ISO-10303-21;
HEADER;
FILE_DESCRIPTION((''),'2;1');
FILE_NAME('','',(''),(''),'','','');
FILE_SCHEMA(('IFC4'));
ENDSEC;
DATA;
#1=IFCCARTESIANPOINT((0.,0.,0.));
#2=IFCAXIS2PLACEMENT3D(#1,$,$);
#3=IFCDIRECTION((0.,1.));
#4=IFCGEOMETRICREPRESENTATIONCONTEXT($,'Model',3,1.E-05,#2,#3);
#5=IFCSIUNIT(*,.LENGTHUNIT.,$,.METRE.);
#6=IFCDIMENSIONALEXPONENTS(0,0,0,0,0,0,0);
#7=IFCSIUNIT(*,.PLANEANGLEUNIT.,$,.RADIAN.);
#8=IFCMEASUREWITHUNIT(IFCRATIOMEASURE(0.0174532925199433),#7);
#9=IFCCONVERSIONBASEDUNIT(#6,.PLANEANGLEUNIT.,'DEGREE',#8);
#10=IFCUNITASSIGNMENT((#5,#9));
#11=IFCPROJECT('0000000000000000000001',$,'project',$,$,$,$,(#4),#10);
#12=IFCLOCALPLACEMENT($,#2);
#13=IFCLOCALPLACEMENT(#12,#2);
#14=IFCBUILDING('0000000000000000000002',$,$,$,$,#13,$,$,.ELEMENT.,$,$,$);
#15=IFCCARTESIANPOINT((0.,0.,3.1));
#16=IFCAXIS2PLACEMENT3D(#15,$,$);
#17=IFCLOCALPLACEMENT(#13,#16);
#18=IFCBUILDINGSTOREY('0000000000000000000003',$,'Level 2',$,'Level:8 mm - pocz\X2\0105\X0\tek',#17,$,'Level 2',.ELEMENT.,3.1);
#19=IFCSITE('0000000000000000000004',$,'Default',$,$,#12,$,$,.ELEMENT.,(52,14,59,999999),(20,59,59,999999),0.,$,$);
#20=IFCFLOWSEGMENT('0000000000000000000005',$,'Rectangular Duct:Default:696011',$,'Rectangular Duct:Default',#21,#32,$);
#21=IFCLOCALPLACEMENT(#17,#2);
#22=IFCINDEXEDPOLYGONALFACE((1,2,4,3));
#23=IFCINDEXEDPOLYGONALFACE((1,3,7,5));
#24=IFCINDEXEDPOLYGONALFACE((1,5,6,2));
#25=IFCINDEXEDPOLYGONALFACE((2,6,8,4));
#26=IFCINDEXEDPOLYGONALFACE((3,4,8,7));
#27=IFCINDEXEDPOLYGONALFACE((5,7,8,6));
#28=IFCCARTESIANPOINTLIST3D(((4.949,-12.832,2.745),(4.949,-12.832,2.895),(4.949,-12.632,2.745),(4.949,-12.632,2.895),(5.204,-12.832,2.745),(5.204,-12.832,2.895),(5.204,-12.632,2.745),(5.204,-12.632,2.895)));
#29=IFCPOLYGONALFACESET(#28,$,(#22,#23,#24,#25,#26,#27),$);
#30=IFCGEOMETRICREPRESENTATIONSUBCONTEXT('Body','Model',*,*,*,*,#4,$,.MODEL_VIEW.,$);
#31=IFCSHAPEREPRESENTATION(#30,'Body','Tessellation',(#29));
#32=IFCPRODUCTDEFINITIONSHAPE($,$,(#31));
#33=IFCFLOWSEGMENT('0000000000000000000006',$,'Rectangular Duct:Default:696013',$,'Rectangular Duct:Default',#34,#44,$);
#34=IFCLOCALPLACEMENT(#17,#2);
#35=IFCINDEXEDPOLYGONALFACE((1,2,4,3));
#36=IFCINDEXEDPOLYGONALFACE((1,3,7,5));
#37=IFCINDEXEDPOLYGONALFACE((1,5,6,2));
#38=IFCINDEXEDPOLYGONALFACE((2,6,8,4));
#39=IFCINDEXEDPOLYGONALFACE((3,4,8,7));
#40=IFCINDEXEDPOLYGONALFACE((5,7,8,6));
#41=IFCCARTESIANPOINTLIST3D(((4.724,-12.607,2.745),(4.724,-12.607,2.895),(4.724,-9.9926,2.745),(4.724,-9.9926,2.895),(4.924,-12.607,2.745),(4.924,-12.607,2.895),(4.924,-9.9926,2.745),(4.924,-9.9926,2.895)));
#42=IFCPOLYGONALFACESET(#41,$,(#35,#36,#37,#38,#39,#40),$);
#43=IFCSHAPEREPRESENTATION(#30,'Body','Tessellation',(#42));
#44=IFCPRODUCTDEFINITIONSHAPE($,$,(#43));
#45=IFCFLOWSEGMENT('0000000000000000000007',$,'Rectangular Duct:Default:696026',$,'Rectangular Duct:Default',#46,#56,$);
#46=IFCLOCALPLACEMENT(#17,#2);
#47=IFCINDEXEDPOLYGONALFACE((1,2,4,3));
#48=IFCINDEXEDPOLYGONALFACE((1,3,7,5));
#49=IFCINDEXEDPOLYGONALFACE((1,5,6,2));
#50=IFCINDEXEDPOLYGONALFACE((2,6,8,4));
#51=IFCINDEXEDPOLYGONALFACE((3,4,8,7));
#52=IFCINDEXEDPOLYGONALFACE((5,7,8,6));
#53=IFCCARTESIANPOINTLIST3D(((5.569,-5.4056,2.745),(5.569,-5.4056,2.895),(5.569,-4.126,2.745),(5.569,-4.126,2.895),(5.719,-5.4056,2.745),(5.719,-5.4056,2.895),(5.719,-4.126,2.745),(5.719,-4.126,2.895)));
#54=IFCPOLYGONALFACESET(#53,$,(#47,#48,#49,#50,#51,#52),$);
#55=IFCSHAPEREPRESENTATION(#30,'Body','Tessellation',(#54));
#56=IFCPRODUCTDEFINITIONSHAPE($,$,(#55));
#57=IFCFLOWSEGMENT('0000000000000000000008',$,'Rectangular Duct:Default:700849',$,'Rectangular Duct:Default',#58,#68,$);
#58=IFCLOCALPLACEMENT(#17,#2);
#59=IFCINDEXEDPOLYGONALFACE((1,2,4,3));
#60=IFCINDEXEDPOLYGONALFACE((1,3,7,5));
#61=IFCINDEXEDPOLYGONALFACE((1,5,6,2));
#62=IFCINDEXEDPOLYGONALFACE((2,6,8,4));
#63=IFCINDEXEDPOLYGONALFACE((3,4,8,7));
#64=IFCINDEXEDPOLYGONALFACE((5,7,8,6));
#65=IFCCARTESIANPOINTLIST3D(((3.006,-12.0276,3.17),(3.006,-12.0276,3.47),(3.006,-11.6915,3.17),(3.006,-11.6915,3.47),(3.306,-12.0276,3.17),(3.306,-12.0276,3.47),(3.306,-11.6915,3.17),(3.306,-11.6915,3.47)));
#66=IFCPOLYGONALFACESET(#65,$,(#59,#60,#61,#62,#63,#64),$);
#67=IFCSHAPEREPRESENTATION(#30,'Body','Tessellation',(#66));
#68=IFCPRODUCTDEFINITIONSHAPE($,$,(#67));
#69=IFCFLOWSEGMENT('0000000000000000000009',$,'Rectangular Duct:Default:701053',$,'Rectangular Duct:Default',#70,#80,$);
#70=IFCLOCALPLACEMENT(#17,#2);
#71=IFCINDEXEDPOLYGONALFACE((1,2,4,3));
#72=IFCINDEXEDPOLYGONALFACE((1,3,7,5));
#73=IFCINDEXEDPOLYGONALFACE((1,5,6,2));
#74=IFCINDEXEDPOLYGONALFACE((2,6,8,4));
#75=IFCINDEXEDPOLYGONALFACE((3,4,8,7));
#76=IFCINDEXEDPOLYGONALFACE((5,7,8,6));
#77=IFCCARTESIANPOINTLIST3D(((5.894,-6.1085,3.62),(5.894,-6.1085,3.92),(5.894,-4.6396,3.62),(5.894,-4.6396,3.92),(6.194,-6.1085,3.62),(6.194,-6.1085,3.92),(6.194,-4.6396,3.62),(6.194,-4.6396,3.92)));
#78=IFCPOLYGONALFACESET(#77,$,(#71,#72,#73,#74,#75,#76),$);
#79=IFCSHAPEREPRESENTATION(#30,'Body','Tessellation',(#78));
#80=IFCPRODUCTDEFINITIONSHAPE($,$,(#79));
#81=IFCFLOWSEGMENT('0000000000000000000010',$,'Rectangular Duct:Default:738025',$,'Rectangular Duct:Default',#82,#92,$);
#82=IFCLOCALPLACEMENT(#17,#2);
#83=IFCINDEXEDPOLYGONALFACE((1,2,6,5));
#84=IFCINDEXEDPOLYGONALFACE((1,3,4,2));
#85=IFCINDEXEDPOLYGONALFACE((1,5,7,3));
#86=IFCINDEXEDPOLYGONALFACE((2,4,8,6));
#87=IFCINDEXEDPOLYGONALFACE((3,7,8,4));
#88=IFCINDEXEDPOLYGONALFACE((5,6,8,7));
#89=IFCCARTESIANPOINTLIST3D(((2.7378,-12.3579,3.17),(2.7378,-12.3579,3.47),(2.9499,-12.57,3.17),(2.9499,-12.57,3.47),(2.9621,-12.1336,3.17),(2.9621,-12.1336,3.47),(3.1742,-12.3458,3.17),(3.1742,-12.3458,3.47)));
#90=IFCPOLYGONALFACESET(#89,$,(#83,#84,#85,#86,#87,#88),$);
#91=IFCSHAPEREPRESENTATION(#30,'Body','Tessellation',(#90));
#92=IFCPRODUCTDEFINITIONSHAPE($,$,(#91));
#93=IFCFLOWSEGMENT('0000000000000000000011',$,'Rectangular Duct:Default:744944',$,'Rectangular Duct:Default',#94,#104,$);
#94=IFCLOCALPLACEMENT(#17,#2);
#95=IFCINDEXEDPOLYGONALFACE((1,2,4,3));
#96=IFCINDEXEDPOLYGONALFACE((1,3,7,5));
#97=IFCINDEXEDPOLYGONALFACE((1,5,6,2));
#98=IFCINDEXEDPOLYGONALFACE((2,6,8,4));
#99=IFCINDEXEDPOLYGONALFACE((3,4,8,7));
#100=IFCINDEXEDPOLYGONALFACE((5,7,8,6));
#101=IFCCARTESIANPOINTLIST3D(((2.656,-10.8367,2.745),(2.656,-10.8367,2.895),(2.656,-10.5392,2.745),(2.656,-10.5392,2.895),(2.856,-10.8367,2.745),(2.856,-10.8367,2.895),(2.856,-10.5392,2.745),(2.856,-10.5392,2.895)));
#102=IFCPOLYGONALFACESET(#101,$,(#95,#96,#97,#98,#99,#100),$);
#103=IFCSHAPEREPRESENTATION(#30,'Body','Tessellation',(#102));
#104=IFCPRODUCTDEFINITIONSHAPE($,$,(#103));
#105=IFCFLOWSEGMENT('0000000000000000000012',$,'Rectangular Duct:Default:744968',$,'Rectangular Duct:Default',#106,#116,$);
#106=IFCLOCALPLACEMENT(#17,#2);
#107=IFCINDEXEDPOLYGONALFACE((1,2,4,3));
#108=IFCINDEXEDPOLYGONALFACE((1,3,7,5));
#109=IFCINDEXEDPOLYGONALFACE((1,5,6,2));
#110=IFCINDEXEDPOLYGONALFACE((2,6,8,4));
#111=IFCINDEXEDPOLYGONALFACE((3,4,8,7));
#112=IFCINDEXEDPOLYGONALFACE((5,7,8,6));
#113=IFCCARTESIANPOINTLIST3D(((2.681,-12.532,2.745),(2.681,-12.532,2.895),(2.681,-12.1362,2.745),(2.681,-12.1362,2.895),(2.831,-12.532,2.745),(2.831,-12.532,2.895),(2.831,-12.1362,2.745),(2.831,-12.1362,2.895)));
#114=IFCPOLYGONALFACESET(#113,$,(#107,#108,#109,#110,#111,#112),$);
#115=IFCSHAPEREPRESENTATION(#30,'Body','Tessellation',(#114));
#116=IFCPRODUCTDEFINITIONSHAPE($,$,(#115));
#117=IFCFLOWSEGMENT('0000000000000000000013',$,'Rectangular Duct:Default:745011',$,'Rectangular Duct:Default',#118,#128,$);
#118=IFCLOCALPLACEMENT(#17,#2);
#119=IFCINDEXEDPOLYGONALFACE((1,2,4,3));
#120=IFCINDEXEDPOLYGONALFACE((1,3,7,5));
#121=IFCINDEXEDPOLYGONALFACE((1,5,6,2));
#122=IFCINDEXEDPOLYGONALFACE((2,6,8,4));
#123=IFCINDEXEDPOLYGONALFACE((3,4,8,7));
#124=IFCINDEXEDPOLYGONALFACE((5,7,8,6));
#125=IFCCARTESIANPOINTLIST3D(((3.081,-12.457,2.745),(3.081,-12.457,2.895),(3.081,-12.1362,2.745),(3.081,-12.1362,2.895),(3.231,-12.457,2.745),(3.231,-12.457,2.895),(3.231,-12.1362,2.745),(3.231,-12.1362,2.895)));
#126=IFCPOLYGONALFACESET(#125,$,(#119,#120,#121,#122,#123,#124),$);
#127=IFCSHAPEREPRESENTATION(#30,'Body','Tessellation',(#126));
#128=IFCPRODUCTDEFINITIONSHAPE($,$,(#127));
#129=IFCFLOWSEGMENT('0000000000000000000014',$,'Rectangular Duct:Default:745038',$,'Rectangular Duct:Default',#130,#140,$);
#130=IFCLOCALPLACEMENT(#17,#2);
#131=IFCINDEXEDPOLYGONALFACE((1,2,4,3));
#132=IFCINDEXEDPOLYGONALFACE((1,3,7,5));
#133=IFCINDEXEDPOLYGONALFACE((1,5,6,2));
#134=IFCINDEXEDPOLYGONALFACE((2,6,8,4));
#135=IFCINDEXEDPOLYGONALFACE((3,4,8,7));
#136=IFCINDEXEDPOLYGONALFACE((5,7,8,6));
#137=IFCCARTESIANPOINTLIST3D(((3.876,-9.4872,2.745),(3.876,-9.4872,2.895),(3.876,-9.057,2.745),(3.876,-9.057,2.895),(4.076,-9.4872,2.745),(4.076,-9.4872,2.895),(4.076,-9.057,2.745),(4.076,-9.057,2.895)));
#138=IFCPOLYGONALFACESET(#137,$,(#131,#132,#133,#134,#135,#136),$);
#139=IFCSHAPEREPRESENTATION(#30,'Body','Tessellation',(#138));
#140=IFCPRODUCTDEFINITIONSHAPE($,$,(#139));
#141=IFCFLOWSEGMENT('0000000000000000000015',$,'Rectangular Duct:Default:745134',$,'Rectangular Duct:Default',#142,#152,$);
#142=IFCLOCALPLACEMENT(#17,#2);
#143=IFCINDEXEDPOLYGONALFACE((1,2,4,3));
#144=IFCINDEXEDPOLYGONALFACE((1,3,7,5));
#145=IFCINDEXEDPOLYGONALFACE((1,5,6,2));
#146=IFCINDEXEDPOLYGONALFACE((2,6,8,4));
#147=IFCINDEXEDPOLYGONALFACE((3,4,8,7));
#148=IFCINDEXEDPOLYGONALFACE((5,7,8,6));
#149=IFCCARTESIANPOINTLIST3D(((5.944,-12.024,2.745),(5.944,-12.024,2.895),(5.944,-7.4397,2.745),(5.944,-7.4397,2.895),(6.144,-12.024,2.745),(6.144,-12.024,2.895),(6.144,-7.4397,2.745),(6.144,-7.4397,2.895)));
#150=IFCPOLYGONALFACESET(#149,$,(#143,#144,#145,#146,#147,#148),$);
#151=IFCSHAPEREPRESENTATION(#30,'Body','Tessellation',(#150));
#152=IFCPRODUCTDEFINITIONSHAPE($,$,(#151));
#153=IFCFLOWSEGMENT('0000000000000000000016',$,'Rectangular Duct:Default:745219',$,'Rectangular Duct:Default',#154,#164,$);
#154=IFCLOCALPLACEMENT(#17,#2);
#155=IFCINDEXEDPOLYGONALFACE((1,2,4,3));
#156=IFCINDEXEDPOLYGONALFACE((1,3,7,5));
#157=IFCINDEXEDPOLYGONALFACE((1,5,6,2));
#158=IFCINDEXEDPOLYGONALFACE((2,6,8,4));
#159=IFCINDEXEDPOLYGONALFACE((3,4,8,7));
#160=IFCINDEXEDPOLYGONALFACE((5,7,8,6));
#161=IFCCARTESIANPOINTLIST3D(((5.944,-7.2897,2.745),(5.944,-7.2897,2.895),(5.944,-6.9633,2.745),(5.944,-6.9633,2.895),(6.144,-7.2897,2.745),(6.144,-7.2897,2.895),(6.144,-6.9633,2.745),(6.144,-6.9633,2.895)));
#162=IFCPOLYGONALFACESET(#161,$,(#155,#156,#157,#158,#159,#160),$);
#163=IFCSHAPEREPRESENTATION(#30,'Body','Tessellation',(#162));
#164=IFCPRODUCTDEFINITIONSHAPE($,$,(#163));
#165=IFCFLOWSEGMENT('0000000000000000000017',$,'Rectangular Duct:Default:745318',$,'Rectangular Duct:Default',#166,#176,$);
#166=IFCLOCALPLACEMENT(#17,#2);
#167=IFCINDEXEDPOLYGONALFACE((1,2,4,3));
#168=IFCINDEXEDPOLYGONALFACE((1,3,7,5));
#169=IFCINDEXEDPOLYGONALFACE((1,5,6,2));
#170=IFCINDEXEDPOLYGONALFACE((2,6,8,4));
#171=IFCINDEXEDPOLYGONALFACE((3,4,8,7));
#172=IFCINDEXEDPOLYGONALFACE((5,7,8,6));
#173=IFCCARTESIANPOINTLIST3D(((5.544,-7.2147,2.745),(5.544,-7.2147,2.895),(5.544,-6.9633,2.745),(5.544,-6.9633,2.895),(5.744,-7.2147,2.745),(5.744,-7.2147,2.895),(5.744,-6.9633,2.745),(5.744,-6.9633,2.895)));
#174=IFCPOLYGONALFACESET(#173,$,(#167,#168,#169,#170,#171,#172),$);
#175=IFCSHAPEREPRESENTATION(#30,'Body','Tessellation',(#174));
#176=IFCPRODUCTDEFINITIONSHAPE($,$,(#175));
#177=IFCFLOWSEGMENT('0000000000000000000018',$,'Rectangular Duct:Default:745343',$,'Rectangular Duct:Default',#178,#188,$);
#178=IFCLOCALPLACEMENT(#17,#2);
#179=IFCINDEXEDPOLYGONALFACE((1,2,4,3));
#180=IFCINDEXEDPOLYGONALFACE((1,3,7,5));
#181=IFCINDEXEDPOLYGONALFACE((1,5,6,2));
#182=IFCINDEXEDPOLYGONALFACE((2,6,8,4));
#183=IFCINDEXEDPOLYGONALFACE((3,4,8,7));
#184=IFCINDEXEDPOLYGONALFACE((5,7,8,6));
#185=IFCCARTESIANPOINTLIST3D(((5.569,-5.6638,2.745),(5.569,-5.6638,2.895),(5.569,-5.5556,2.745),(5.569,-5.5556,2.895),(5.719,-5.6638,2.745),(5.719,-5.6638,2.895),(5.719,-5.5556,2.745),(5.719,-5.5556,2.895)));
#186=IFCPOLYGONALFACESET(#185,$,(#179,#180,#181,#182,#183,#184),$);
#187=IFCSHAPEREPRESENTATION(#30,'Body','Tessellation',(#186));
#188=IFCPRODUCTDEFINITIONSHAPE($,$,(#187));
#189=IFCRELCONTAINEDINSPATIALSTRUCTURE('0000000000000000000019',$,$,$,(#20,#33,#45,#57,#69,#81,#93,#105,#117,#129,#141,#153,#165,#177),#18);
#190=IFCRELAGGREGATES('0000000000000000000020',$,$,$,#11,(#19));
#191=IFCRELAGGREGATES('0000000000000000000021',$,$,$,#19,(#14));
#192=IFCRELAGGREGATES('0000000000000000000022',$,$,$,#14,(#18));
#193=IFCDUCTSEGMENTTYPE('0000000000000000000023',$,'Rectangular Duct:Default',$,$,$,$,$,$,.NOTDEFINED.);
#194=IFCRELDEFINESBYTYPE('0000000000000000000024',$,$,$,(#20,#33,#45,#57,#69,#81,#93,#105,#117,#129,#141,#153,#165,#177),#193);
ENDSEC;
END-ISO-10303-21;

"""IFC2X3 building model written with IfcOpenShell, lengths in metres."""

from ifc_helpers import new_model, entity, si_unit, converted_unit, direction, frame, frame_2d, origin, origin_2d_with_axis, place, context, subcontext, project, spatial, rectangle, extrude, type_object, element, save


model = new_model("IFC2X3")

# Units and contexts
model_context = context("Model", 3, precision=1e-05, world=origin(), true_north=direction((0.0, 1.0)))
body_context = subcontext(model_context, "Body", "Model", "MODEL_VIEW")
ifc_project = project(units=[si_unit("LENGTHUNIT", "METRE"), converted_unit("PLANEANGLEUNIT", "DEGREE", entity("IfcRatioMeasure", 0.0174532925199433), si_unit("PLANEANGLEUNIT", "RADIAN"), dimensions=[0, 0, 0, 0, 0, 0, 0])], contexts=[model_context])

# Site, building, storey
site_placement = place(None, origin())
site = spatial("IfcSite", under=ifc_project, at=site_placement, Name="Default", CompositionType="ELEMENT", RefLatitude=(52, 14, 59, 999999), RefLongitude=(20, 59, 59, 999999), RefElevation=0.0)
building_placement = place(site_placement, origin())
building = spatial("IfcBuilding", under=site, at=building_placement, CompositionType="ELEMENT")
storey_placement = place(building_placement, frame((0.0, 0.0, 3.1)))
storey = spatial("IfcBuildingStorey", under=building, at=storey_placement, Name="Level 2", ObjectType="Level:8 mm - początek", LongName="Level 2", CompositionType="ELEMENT", Elevation=3.1)

# Flow segments
duct_segment_type = type_object("IfcDuctSegmentType", Name="Rectangular Duct:Default", PredefinedType="NOTDEFINED")
flow_segment_1_placement = place(storey_placement, origin())
element("IfcFlowSegment", 1, at=flow_segment_1_placement, inside=storey, type_object=duct_segment_type, Name="Rectangular Duct:Default:696011", ObjectType="Rectangular Duct:Default", context=body_context, shape_type="SweptSolid", body=[
    extrude(rectangle(XDim=0.255, YDim=0.2, at=frame_2d((0.0, 0.0), x_axis=(1.0, 0.0))), frame((5.0765, -12.732, 2.745)), (0.0, 0.0, 1.0), 0.15),
])
flow_segment_2_placement = place(storey_placement, origin())
element("IfcFlowSegment", 2, at=flow_segment_2_placement, inside=storey, type_object=duct_segment_type, Name="Rectangular Duct:Default:696013", ObjectType="Rectangular Duct:Default", context=body_context, shape_type="SweptSolid", body=[
    extrude(rectangle(XDim=2.6144, YDim=0.2, at=frame_2d((0.0, 0.0), x_axis=(1.0, 0.0))), frame((4.824, -11.2998, 2.745), z_axis=(0.0, 0.0, 1.0), x_axis=(0.0, -1.0, 0.0)), (0.0, 0.0, 1.0), 0.15),
])
flow_segment_3_placement = place(storey_placement, origin())
element("IfcFlowSegment", 3, at=flow_segment_3_placement, inside=storey, type_object=duct_segment_type, Name="Rectangular Duct:Default:696026", ObjectType="Rectangular Duct:Default", context=body_context, shape_type="SweptSolid", body=[
    extrude(rectangle(XDim=1.2796, YDim=0.15, at=frame_2d((0.0, 0.0), x_axis=(1.0, 0.0))), frame((5.644, -4.7658, 2.745), z_axis=(0.0, 0.0, 1.0), x_axis=(0.0, 1.0, 0.0)), (0.0, 0.0, 1.0), 0.15),
])
flow_segment_4_placement = place(storey_placement, origin())
element("IfcFlowSegment", 4, at=flow_segment_4_placement, inside=storey, type_object=duct_segment_type, Name="Rectangular Duct:Default:700849", ObjectType="Rectangular Duct:Default", context=body_context, shape_type="SweptSolid", body=[
    extrude(rectangle(XDim=0.3361, YDim=0.3, at=frame_2d((0.0, 0.0), x_axis=(1.0, 0.0))), frame((3.156, -11.8595, 3.17), z_axis=(0.0, 0.0, 1.0), x_axis=(0.0, -1.0, 0.0)), (0.0, 0.0, 1.0), 0.3),
])
flow_segment_5_placement = place(storey_placement, origin())
element("IfcFlowSegment", 5, at=flow_segment_5_placement, inside=storey, type_object=duct_segment_type, Name="Rectangular Duct:Default:701053", ObjectType="Rectangular Duct:Default", context=body_context, shape_type="SweptSolid", body=[
    extrude(rectangle(XDim=1.4689, YDim=0.3, at=frame_2d((0.0, 0.0), x_axis=(1.0, 0.0))), frame((6.044, -5.3741, 3.62), z_axis=(0.0, 0.0, 1.0), x_axis=(0.0, 1.0, 0.0)), (0.0, 0.0, 1.0), 0.3),
])
flow_segment_6_placement = place(storey_placement, origin())
element("IfcFlowSegment", 6, at=flow_segment_6_placement, inside=storey, type_object=duct_segment_type, Name="Rectangular Duct:Default:738025", ObjectType="Rectangular Duct:Default", context=body_context, shape_type="SweptSolid", body=[
    extrude(rectangle(XDim=0.3172, YDim=0.3, at=origin_2d_with_axis()), frame((2.956, -12.3518, 3.17), z_axis=(0.0, 0.0, 1.0), x_axis=(0.707107, 0.707107, 0.0)), (0.0, 0.0, 1.0), 0.3),
])
flow_segment_7_placement = place(storey_placement, origin())
element("IfcFlowSegment", 7, at=flow_segment_7_placement, inside=storey, type_object=duct_segment_type, Name="Rectangular Duct:Default:744944", ObjectType="Rectangular Duct:Default", context=body_context, shape_type="SweptSolid", body=[
    extrude(rectangle(XDim=0.2975, YDim=0.2, at=frame_2d((0.0, 0.0), x_axis=(1.0, 0.0))), frame((2.756, -10.6879, 2.745), z_axis=(0.0, 0.0, 1.0), x_axis=(0.0, 1.0, 0.0)), (0.0, 0.0, 1.0), 0.15),
])
flow_segment_8_placement = place(storey_placement, origin())
element("IfcFlowSegment", 8, at=flow_segment_8_placement, inside=storey, type_object=duct_segment_type, Name="Rectangular Duct:Default:744968", ObjectType="Rectangular Duct:Default", context=body_context, shape_type="SweptSolid", body=[
    extrude(rectangle(XDim=0.3958, YDim=0.15, at=origin_2d_with_axis()), frame((2.756, -12.3341, 2.745), z_axis=(0.0, 0.0, 1.0), x_axis=(0.0, -1.0, 0.0)), (0.0, 0.0, 1.0), 0.15),
])
flow_segment_9_placement = place(storey_placement, origin())
element("IfcFlowSegment", 9, at=flow_segment_9_placement, inside=storey, type_object=duct_segment_type, Name="Rectangular Duct:Default:745011", ObjectType="Rectangular Duct:Default", context=body_context, shape_type="SweptSolid", body=[
    extrude(rectangle(XDim=0.3208, YDim=0.15, at=origin_2d_with_axis()), frame((3.156, -12.2966, 2.745), z_axis=(0.0, 0.0, 1.0), x_axis=(0.0, -1.0, 0.0)), (0.0, 0.0, 1.0), 0.15),
])
flow_segment_10_placement = place(storey_placement, origin())
element("IfcFlowSegment", 10, at=flow_segment_10_placement, inside=storey, type_object=duct_segment_type, Name="Rectangular Duct:Default:745038", ObjectType="Rectangular Duct:Default", context=body_context, shape_type="SweptSolid", body=[
    extrude(rectangle(XDim=0.4302, YDim=0.2, at=frame_2d((0.0, 0.0), x_axis=(1.0, 0.0))), frame((3.976, -9.2721, 2.745), z_axis=(0.0, 0.0, 1.0), x_axis=(0.0, 1.0, 0.0)), (0.0, 0.0, 1.0), 0.15),
])
flow_segment_11_placement = place(storey_placement, origin())
element("IfcFlowSegment", 11, at=flow_segment_11_placement, inside=storey, type_object=duct_segment_type, Name="Rectangular Duct:Default:745134", ObjectType="Rectangular Duct:Default", context=body_context, shape_type="SweptSolid", body=[
    extrude(rectangle(XDim=4.5843, YDim=0.2, at=origin_2d_with_axis()), frame((6.044, -9.7319, 2.745), z_axis=(0.0, 0.0, 1.0), x_axis=(0.0, -1.0, 0.0)), (0.0, 0.0, 1.0), 0.15),
])
flow_segment_12_placement = place(storey_placement, origin())
element("IfcFlowSegment", 12, at=flow_segment_12_placement, inside=storey, type_object=duct_segment_type, Name="Rectangular Duct:Default:745219", ObjectType="Rectangular Duct:Default", context=body_context, shape_type="SweptSolid", body=[
    extrude(rectangle(XDim=0.3264, YDim=0.2, at=frame_2d((0.0, 0.0), x_axis=(1.0, 0.0))), frame((6.044, -7.1265, 2.745), z_axis=(0.0, 0.0, 1.0), x_axis=(0.0, -1.0, 0.0)), (0.0, 0.0, 1.0), 0.15),
])
flow_segment_13_placement = place(storey_placement, origin())
element("IfcFlowSegment", 13, at=flow_segment_13_placement, inside=storey, type_object=duct_segment_type, Name="Rectangular Duct:Default:745318", ObjectType="Rectangular Duct:Default", context=body_context, shape_type="SweptSolid", body=[
    extrude(rectangle(XDim=0.2514, YDim=0.2, at=frame_2d((0.0, 0.0), x_axis=(1.0, 0.0))), frame((5.644, -7.089, 2.745), z_axis=(0.0, 0.0, 1.0), x_axis=(0.0, -1.0, 0.0)), (0.0, 0.0, 1.0), 0.15),
])
flow_segment_14_placement = place(storey_placement, origin())
element("IfcFlowSegment", 14, at=flow_segment_14_placement, inside=storey, type_object=duct_segment_type, Name="Rectangular Duct:Default:745343", ObjectType="Rectangular Duct:Default", context=body_context, shape_type="SweptSolid", body=[
    extrude(rectangle(XDim=0.1082, YDim=0.15, at=origin_2d_with_axis()), frame((5.644, -5.6097, 2.745), z_axis=(0.0, 0.0, 1.0), x_axis=(0.0, 1.0, 0.0)), (0.0, 0.0, 1.0), 0.15),
])

save(model, "model.ifc")
